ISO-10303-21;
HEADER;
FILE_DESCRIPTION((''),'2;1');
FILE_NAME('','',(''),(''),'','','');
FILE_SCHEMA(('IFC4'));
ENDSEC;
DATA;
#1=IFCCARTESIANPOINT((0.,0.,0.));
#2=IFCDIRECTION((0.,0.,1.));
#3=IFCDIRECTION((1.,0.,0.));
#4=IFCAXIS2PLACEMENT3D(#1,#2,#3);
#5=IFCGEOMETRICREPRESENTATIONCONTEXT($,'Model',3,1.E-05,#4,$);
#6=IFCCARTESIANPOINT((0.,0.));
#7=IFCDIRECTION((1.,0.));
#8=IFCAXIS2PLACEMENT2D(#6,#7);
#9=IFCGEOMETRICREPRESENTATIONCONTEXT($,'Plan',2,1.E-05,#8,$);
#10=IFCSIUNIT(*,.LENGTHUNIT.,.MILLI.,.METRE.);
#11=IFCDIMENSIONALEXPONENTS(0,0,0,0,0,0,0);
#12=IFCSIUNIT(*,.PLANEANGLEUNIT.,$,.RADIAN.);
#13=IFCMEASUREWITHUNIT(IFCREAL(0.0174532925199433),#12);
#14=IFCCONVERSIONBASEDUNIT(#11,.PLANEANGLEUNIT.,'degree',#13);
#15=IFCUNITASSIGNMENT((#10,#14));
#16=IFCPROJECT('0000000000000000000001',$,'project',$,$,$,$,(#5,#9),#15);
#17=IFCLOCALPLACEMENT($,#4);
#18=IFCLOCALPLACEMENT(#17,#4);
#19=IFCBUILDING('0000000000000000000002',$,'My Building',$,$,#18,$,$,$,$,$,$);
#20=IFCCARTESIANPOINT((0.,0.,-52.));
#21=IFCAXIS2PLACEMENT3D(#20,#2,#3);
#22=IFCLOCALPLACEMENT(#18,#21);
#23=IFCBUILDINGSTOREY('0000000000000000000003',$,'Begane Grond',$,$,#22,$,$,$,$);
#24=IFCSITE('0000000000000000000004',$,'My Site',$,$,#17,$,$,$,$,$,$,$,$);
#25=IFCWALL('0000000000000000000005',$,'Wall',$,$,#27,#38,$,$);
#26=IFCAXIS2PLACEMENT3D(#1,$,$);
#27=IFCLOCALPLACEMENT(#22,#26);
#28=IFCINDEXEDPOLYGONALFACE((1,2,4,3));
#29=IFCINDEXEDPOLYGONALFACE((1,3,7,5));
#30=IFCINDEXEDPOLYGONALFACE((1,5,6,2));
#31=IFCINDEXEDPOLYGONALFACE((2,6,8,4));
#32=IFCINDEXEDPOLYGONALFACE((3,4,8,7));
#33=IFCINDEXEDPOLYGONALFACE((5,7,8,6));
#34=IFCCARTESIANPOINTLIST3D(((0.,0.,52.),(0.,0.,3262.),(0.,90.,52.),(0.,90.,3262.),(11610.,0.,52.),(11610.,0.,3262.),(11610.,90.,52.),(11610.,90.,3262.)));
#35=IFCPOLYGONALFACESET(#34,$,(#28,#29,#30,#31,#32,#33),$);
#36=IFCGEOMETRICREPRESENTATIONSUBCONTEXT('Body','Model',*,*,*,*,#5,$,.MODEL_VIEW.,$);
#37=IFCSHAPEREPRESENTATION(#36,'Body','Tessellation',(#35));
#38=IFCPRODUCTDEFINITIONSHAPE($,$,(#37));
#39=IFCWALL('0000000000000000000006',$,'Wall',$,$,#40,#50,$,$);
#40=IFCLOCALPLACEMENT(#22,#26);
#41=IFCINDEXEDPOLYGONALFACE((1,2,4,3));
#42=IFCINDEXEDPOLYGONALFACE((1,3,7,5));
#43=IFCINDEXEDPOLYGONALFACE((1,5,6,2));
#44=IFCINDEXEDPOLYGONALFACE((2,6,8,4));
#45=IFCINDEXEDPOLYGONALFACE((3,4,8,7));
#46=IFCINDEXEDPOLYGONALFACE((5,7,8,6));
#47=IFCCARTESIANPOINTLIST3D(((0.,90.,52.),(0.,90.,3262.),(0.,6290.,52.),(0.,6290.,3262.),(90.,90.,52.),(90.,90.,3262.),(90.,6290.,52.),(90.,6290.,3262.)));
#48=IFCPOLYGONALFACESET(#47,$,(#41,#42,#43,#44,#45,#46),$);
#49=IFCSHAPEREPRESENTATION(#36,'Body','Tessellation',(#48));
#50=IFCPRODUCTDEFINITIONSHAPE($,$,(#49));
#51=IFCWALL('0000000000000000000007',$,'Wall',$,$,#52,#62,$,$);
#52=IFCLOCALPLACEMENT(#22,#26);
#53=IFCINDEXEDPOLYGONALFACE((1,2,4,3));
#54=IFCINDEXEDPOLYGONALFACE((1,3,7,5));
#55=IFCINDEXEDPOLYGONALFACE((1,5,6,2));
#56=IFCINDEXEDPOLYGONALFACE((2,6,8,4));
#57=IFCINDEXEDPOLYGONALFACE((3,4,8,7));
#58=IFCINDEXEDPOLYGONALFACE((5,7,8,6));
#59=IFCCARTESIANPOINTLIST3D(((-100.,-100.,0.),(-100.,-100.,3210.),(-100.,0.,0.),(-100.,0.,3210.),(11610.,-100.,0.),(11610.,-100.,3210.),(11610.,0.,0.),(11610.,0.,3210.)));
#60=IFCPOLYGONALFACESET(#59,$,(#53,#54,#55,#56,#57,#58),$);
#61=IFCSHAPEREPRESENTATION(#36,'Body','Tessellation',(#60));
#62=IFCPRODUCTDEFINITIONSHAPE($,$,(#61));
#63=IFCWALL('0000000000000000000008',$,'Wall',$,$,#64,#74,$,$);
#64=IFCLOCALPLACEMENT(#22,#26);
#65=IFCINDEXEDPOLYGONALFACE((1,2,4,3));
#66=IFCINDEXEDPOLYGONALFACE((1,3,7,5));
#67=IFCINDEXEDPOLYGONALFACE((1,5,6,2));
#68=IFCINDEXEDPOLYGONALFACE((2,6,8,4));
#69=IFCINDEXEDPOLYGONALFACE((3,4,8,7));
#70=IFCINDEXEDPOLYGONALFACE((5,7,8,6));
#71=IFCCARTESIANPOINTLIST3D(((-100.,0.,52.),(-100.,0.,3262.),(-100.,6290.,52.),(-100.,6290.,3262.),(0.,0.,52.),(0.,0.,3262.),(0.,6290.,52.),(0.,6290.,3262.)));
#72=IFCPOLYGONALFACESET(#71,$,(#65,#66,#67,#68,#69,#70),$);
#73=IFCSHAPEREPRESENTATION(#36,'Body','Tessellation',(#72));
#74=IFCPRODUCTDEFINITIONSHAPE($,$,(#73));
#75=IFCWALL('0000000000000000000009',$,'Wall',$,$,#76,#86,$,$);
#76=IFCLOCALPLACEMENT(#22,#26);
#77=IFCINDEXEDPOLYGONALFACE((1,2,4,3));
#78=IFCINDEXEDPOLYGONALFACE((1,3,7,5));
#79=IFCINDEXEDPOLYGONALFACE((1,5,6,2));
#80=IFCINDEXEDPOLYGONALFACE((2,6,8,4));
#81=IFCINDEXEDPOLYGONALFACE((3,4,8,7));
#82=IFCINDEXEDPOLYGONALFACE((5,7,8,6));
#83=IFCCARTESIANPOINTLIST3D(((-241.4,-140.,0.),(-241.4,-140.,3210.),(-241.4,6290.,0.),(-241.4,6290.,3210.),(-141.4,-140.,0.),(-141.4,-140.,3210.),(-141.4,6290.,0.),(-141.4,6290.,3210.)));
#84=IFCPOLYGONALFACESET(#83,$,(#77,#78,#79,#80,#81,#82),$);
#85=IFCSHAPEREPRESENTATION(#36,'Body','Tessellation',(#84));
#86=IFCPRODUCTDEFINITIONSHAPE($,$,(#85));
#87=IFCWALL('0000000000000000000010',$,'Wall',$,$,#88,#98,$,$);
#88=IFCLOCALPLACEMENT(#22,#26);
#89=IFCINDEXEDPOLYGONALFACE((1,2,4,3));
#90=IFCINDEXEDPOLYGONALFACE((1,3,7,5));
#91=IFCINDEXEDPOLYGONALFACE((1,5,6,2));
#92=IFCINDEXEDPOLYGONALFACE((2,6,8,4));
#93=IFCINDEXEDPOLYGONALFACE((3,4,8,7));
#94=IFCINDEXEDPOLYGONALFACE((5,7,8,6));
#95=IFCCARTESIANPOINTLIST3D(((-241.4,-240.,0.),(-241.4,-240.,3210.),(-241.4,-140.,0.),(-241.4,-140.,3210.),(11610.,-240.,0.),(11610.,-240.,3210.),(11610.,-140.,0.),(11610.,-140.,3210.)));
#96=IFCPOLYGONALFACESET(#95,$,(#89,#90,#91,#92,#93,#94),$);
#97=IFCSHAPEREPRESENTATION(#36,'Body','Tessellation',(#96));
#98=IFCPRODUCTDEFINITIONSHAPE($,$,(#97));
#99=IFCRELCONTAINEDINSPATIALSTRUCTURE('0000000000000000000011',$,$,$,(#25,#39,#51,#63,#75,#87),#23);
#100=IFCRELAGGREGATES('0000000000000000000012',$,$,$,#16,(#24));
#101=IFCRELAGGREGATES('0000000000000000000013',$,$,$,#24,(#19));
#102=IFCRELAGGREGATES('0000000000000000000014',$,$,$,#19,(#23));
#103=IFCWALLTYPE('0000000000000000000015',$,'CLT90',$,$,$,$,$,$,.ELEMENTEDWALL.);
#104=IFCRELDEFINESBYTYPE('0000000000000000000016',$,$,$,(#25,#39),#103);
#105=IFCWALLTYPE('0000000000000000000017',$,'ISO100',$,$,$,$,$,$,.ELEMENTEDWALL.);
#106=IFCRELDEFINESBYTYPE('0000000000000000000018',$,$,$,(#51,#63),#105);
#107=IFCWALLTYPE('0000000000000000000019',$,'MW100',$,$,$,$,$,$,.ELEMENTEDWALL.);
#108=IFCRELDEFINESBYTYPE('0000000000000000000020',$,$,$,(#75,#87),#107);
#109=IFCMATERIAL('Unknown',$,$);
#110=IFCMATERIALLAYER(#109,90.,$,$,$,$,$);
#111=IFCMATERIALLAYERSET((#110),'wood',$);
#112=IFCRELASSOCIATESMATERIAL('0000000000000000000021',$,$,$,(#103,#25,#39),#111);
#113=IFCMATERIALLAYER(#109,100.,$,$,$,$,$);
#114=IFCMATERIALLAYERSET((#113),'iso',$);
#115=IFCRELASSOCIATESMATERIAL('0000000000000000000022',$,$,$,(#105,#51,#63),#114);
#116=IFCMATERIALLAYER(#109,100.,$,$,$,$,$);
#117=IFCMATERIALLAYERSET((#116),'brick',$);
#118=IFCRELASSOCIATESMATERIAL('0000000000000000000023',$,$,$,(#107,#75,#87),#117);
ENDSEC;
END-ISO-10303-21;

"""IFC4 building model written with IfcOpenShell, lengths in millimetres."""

from ifc_helpers import new_model, entity, si_unit, converted_unit, frame, origin_with_axes, origin_2d_with_axis, place, context, subcontext, project, spatial, indexed_curve, outline, extrude, material, layer, layer_set, layer_usage, type_object, element, save


model = new_model("IFC4")

# Units and contexts
model_context = context("Model", 3, precision=1e-05, world=origin_with_axes())
plan_context = context("Plan", 2, precision=1e-05, world=origin_2d_with_axis())
body_context = subcontext(model_context, "Body", "Model", "MODEL_VIEW")
ifc_project = project(units=[si_unit("LENGTHUNIT", "METRE", prefix="MILLI"), converted_unit("PLANEANGLEUNIT", "degree", entity("IfcReal", 0.0174532925199433), si_unit("PLANEANGLEUNIT", "RADIAN"), dimensions=[0, 0, 0, 0, 0, 0, 0])], contexts=[model_context, plan_context])

# Site, building, storey
site_placement = place(None, origin_with_axes())
site = spatial("IfcSite", under=ifc_project, at=site_placement, Name="My Site")
building_placement = place(site_placement, origin_with_axes())
building = spatial("IfcBuilding", under=site, at=building_placement, Name="My Building")
storey_placement = place(building_placement, frame((0.0, 0.0, -52.0), z_axis=(0.0, 0.0, 1.0), x_axis=(1.0, 0.0, 0.0)))
storey = spatial("IfcBuildingStorey", under=building, at=storey_placement, Name="Begane Grond")

# Walls
ifc_material = material(Name="Unknown")
ifc_layer_1 = layer(ifc_material, 90.0)
ifc_layer_set_1 = layer_set([ifc_layer_1], Name="wood")
ifc_layer_usage_1 = layer_usage(ifc_layer_set_1, "AXIS2", "POSITIVE", 0.0)
wall_type_1 = type_object("IfcWallType", Name="CLT90", PredefinedType="ELEMENTEDWALL", material=ifc_layer_set_1)
wall_1_placement = place(storey_placement, frame((0.0, 0.0, 52.0), z_axis=(0.0, 0.0, 1.0), x_axis=(1.0, 0.0, 0.0)))
element("IfcWall", 1, at=wall_1_placement, inside=storey, type_object=wall_type_1, material=ifc_layer_usage_1, Name="Wall", context=body_context, shape_type="SweptSolid", body=[
    extrude(outline(indexed_curve([(0.0, 0.0), (0.0, 90.0), (11610.0, 90.0), (11610.0, 0.0), (0.0, 0.0)], self_intersect=False)), origin_with_axes(), (0.0, 0.0, 1.0), 3210.0),
])
ifc_layer_usage_2 = layer_usage(ifc_layer_set_1, "AXIS2", "POSITIVE", 0.0)
wall_2_placement = place(storey_placement, frame((90.0, 90.0, 52.0), z_axis=(0.0, 0.0, 1.0), x_axis=(0.0, 1.0, 0.0)))
element("IfcWall", 2, at=wall_2_placement, inside=storey, type_object=wall_type_1, material=ifc_layer_usage_2, Name="Wall", context=body_context, shape_type="SweptSolid", body=[
    extrude(outline(indexed_curve([(0.0, 0.0), (0.0, 90.0), (6200.0, 90.0), (6200.0, 0.0), (0.0, 0.0)], self_intersect=False)), origin_with_axes(), (0.0, 0.0, 1.0), 3210.0),
])
ifc_layer_2 = layer(ifc_material, 100.0)
ifc_layer_set_2 = layer_set([ifc_layer_2], Name="iso")
ifc_layer_usage_3 = layer_usage(ifc_layer_set_2, "AXIS2", "POSITIVE", 0.0)
wall_type_2 = type_object("IfcWallType", Name="ISO100", PredefinedType="ELEMENTEDWALL", material=ifc_layer_set_2)
wall_3_placement = place(storey_placement, frame((-100.0, -100.0, 0.0), z_axis=(0.0, 0.0, 1.0), x_axis=(1.0, 0.0, 0.0)))
element("IfcWall", 3, at=wall_3_placement, inside=storey, type_object=wall_type_2, material=ifc_layer_usage_3, Name="Wall", context=body_context, shape_type="SweptSolid", body=[
    extrude(outline(indexed_curve([(0.0, 0.0), (0.0, 100.0), (11710.0, 100.0), (11710.0, 0.0), (0.0, 0.0)], self_intersect=False)), origin_with_axes(), (0.0, 0.0, 1.0), 3210.0),
])
ifc_layer_usage_4 = layer_usage(ifc_layer_set_2, "AXIS2", "POSITIVE", 0.0)
wall_4_placement = place(storey_placement, frame((0.0, 0.0, 52.0), z_axis=(0.0, 0.0, 1.0), x_axis=(0.0, 1.0, 0.0)))
element("IfcWall", 4, at=wall_4_placement, inside=storey, type_object=wall_type_2, material=ifc_layer_usage_4, Name="Wall", context=body_context, shape_type="SweptSolid", body=[
    extrude(outline(indexed_curve([(0.0, 0.0), (0.0, 100.0), (6290.0, 100.0), (6290.0, 0.0), (0.0, 0.0)], self_intersect=False)), origin_with_axes(), (0.0, 0.0, 1.0), 3210.0),
])
ifc_layer_3 = layer(ifc_material, 100.0)
ifc_layer_set_3 = layer_set([ifc_layer_3], Name="brick")
ifc_layer_usage_5 = layer_usage(ifc_layer_set_3, "AXIS2", "POSITIVE", 0.0)
wall_type_3 = type_object("IfcWallType", Name="MW100", PredefinedType="ELEMENTEDWALL", material=ifc_layer_set_3)
wall_5_placement = place(storey_placement, frame((-141.4, -140.0, 0.0), z_axis=(0.0, 0.0, 1.0), x_axis=(0.0, 1.0, 0.0)))
element("IfcWall", 5, at=wall_5_placement, inside=storey, type_object=wall_type_3, material=ifc_layer_usage_5, Name="Wall", context=body_context, shape_type="SweptSolid", body=[
    extrude(outline(indexed_curve([(0.0, 0.0), (0.0, 100.0), (6430.0, 100.0), (6430.0, 0.0), (0.0, 0.0)], self_intersect=False)), origin_with_axes(), (0.0, 0.0, 1.0), 3210.0),
])
ifc_layer_usage_6 = layer_usage(ifc_layer_set_3, "AXIS2", "POSITIVE", 0.0)
wall_6_placement = place(storey_placement, frame((-241.4, -240.0, 0.0), z_axis=(0.0, 0.0, 1.0), x_axis=(1.0, 0.0, 0.0)))
element("IfcWall", 6, at=wall_6_placement, inside=storey, type_object=wall_type_3, material=ifc_layer_usage_6, Name="Wall", context=body_context, shape_type="SweptSolid", body=[
    extrude(outline(indexed_curve([(0.0, 0.0), (0.0, 100.0), (11851.4, 100.0), (11851.4, 0.0), (0.0, 0.0)], self_intersect=False)), origin_with_axes(), (0.0, 0.0, 1.0), 3210.0),
])

save(model, "model.ifc")
